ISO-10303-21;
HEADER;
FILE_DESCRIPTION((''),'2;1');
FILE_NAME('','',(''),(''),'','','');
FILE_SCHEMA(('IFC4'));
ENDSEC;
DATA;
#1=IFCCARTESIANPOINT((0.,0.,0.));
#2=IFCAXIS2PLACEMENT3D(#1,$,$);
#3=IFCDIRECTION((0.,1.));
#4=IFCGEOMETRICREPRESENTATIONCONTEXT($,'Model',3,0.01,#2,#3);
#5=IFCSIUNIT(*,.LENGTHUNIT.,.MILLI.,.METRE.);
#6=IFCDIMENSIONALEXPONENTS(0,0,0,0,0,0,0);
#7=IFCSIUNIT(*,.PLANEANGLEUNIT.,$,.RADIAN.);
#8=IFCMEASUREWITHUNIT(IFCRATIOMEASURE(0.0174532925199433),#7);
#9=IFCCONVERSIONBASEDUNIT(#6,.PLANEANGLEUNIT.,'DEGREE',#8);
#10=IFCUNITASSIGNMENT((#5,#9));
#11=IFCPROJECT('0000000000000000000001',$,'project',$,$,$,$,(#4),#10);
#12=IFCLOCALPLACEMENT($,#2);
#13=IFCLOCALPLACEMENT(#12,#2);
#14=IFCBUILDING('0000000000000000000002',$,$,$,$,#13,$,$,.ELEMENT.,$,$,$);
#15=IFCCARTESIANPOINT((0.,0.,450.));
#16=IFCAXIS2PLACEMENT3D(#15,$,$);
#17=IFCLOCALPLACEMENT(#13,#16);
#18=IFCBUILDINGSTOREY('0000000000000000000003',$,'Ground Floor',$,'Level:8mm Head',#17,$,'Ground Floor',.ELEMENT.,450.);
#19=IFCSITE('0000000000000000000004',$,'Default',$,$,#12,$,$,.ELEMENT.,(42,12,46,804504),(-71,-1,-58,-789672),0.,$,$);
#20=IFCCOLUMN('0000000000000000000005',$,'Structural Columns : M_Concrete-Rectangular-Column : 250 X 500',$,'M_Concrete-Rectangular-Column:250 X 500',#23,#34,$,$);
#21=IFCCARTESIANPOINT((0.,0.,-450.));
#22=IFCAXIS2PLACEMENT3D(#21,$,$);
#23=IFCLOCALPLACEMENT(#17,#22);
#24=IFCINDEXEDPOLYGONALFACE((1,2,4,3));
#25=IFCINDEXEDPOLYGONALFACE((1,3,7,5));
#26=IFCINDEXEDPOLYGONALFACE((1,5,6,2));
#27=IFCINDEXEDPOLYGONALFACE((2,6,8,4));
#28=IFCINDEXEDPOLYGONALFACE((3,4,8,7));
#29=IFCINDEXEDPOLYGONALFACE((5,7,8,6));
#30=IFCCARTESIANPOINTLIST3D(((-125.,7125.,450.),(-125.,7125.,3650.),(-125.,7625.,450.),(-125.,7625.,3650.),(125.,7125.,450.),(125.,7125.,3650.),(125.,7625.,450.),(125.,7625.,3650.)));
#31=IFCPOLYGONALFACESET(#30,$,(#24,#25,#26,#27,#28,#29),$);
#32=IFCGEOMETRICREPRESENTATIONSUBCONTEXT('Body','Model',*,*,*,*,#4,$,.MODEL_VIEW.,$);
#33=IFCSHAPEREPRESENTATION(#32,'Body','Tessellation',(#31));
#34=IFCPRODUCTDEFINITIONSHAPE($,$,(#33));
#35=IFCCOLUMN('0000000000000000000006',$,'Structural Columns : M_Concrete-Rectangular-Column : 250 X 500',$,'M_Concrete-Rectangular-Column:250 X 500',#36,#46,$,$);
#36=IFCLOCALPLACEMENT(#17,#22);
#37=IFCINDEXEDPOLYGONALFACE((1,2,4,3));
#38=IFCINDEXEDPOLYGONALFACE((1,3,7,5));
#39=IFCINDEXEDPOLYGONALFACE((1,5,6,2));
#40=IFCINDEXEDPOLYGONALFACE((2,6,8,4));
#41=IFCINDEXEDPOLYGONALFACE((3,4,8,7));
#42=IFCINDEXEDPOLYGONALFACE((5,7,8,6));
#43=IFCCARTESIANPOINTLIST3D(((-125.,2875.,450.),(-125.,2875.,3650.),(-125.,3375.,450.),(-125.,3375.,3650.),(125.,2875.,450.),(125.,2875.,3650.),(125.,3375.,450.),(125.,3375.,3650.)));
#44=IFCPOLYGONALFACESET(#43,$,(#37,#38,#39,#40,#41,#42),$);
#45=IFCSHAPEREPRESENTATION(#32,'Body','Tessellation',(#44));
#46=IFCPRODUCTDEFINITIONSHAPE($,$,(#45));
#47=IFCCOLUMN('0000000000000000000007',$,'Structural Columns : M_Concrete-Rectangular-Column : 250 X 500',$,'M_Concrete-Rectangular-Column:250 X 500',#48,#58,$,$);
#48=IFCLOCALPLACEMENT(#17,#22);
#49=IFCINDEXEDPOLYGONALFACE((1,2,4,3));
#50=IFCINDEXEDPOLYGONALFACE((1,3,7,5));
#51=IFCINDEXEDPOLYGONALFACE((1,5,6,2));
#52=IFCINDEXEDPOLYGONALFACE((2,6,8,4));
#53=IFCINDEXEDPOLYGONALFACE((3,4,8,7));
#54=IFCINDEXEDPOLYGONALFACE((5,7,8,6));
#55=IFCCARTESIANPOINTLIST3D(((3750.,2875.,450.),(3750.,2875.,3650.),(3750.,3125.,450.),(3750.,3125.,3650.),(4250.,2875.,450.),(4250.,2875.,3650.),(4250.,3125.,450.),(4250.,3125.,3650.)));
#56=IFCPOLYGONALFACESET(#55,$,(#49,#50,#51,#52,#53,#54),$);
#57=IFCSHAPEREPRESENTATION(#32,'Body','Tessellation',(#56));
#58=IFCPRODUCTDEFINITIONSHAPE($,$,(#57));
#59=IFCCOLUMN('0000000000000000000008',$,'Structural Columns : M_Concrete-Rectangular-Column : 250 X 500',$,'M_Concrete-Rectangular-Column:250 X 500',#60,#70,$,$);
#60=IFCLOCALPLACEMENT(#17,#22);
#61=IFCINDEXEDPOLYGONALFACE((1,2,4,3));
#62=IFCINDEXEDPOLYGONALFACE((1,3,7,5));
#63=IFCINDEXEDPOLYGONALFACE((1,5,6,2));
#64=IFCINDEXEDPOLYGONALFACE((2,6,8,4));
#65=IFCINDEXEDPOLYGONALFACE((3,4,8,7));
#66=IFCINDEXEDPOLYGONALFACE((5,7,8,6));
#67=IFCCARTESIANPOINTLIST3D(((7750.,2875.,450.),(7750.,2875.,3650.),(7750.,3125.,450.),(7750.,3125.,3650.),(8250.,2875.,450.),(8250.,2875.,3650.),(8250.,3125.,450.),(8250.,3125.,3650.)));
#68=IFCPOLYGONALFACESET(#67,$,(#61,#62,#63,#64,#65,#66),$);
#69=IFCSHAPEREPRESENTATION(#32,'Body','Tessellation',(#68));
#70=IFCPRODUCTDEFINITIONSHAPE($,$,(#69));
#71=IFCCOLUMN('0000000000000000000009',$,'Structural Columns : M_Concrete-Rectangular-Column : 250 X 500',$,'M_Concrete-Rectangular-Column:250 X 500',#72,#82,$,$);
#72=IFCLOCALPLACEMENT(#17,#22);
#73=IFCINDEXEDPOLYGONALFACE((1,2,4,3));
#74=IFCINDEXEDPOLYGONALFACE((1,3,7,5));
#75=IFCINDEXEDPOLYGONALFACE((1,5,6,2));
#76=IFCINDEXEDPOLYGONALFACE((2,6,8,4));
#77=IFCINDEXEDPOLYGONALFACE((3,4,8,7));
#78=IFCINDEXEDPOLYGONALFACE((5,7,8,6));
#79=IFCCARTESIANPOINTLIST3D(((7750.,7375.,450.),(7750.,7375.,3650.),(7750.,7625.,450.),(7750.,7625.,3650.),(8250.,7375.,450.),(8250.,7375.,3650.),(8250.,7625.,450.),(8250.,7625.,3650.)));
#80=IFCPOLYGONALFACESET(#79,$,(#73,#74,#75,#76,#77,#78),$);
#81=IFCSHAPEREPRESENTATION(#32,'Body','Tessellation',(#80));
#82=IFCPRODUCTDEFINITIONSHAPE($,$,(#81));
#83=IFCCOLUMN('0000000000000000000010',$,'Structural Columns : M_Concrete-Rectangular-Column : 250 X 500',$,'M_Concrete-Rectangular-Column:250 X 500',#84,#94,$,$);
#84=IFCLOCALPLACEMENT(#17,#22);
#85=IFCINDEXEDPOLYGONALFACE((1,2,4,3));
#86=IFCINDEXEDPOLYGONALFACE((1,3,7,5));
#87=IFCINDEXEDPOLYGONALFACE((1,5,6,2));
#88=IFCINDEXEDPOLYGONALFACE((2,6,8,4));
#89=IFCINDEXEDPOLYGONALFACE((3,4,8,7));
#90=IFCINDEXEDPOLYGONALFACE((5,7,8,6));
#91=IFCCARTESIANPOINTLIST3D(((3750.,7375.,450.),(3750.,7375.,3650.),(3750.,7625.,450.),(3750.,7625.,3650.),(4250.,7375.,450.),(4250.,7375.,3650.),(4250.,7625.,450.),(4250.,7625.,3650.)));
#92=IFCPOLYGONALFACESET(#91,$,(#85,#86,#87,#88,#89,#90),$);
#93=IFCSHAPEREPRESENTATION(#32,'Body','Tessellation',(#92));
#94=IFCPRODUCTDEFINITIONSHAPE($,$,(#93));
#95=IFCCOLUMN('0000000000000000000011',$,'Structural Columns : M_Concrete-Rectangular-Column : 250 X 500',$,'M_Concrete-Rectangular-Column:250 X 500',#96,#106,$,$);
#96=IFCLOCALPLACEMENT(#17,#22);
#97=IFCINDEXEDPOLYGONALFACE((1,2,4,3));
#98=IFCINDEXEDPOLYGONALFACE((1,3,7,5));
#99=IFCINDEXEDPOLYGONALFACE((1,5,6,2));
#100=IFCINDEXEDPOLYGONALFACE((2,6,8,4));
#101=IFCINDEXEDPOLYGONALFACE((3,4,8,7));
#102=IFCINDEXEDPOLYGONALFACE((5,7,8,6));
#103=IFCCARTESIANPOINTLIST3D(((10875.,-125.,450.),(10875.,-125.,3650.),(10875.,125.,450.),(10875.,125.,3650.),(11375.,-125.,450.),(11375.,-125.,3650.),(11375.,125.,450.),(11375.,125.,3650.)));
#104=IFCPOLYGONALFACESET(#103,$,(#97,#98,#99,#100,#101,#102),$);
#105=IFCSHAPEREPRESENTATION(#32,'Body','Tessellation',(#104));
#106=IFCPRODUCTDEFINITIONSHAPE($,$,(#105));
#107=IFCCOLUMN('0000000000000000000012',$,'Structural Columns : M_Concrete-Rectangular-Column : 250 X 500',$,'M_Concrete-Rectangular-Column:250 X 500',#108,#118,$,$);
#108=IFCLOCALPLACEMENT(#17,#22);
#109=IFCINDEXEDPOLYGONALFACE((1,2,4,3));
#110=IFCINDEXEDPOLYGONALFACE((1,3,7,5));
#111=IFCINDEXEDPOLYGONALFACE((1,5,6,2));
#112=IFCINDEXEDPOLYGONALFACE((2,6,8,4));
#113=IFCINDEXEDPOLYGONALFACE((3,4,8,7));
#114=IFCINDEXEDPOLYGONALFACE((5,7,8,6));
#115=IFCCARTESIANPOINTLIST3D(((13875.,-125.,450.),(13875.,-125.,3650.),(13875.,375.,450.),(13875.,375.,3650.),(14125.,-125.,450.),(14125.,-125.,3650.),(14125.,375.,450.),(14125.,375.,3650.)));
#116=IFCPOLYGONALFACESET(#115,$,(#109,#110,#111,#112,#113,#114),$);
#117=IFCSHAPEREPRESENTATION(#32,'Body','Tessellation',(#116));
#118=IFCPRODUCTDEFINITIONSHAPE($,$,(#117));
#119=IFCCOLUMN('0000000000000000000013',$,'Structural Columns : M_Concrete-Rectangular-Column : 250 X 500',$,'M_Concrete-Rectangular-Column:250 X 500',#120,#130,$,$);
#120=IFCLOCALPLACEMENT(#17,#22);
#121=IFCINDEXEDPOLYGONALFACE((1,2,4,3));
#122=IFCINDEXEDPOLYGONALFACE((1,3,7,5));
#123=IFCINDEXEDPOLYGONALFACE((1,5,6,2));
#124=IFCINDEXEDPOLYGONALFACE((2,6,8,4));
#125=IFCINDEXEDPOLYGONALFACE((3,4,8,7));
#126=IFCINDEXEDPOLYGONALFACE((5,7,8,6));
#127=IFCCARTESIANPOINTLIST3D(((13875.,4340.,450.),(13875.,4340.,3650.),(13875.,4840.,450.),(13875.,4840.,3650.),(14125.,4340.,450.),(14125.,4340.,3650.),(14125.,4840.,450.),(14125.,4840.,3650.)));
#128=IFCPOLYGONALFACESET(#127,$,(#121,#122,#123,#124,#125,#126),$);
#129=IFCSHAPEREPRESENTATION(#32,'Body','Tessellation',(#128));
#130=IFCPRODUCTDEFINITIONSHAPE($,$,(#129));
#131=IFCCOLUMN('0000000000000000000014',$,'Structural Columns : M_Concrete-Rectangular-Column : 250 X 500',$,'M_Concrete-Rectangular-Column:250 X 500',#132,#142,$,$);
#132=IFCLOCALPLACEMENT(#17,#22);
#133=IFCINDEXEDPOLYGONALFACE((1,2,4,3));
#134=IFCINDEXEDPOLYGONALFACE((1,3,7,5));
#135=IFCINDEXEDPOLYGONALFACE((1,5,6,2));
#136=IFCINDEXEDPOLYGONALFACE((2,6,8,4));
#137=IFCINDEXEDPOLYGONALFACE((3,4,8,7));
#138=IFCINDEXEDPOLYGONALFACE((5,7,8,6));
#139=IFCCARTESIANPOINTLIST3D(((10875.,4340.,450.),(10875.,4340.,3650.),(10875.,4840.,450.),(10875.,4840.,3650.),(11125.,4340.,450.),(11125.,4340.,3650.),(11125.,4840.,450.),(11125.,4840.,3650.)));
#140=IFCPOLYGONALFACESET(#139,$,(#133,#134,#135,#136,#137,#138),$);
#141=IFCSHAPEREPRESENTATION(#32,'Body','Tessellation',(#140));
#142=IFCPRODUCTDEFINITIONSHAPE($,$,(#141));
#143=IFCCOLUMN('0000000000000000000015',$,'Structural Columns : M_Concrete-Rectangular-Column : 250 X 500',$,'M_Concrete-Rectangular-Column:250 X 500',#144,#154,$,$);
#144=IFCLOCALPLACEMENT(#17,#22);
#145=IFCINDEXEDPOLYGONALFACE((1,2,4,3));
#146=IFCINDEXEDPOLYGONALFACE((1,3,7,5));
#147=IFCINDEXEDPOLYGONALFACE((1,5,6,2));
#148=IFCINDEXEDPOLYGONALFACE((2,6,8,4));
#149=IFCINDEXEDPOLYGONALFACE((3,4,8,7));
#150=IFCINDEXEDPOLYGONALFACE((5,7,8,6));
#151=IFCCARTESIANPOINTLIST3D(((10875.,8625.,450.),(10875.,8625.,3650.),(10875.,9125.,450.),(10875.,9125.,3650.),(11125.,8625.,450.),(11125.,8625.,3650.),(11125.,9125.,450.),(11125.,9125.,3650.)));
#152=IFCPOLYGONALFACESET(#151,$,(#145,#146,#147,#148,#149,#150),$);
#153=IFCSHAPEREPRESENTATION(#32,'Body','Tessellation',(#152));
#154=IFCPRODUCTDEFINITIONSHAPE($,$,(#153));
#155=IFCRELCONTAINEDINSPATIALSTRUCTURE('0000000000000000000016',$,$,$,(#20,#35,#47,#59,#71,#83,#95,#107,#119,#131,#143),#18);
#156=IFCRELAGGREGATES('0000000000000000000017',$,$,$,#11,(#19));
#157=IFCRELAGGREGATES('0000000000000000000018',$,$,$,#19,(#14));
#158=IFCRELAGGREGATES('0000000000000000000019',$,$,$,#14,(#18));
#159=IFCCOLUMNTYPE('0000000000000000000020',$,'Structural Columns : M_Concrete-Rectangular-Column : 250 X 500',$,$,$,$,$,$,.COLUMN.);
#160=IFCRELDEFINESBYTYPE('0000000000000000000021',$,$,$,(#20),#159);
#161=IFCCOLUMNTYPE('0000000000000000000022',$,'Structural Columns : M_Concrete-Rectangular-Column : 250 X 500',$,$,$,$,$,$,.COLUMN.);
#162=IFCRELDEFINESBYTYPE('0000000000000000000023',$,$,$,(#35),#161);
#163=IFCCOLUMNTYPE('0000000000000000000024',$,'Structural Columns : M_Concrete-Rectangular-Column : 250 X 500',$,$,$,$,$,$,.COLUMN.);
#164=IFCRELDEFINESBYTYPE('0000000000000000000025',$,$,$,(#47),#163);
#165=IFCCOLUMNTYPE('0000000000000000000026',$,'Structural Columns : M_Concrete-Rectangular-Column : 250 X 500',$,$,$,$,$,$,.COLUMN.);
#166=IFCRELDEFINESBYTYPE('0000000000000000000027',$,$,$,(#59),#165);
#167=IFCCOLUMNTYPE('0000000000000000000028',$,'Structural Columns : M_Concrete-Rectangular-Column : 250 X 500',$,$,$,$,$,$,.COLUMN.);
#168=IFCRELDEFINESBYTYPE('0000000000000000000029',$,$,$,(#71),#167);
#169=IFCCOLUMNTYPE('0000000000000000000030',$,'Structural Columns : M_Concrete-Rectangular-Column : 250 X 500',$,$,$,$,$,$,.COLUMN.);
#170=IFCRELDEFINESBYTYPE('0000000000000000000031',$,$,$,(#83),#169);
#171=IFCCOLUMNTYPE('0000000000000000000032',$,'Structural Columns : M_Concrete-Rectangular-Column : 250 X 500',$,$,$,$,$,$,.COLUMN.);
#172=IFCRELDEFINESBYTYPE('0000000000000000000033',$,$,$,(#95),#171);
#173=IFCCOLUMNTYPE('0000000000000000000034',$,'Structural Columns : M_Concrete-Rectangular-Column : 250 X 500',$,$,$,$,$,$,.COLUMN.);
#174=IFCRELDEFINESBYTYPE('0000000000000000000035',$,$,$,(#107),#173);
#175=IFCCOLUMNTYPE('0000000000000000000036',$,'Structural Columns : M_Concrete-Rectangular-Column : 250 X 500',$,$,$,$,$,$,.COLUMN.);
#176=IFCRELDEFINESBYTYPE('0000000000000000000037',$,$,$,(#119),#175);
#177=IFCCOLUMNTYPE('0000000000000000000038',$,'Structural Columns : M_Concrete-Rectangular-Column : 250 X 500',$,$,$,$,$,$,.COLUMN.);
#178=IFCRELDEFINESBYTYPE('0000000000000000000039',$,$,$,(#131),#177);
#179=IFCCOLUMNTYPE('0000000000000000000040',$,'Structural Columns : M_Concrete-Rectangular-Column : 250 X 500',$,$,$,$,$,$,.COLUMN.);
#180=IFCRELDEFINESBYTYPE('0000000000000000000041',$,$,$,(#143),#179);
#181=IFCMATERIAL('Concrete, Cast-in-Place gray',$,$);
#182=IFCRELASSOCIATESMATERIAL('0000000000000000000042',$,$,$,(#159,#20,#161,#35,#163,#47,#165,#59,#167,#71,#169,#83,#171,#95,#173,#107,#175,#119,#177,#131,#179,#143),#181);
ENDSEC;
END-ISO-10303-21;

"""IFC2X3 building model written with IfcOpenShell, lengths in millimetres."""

from ifc_helpers import new_model, entity, si_unit, converted_unit, direction, frame, frame_2d, origin, origin_2d_with_axis, place, context, subcontext, project, spatial, rectangle, extrude, source, transform, mapped, material, type_object, type_shapes, element, save


model = new_model("IFC2X3")

# Units and contexts
model_context = context("Model", 3, precision=0.01, world=origin(), true_north=direction((0.0, 1.0)))
body_context = subcontext(model_context, "Body", "Model", "MODEL_VIEW")
ifc_project = project(units=[si_unit("LENGTHUNIT", "METRE", prefix="MILLI"), converted_unit("PLANEANGLEUNIT", "DEGREE", entity("IfcRatioMeasure", 0.0174532925199433), si_unit("PLANEANGLEUNIT", "RADIAN"), dimensions=[0, 0, 0, 0, 0, 0, 0])], contexts=[model_context])

# Site, building, storey
site_placement = place(None, origin())
site = spatial("IfcSite", under=ifc_project, at=site_placement, Name="Default", CompositionType="ELEMENT", RefLatitude=(42, 12, 46, 804504), RefLongitude=(-71, -1, -58, -789672), RefElevation=0.0)
building_placement = place(site_placement, origin())
building = spatial("IfcBuilding", under=site, at=building_placement, CompositionType="ELEMENT")
storey_placement = place(building_placement, frame((0.0, 0.0, 450.0)))
storey = spatial("IfcBuildingStorey", under=building, at=storey_placement, Name="Ground Floor", ObjectType="Level:8mm Head", LongName="Ground Floor", CompositionType="ELEMENT", Elevation=450.0)

# Columns
ifc_material = material(Name="Concrete, Cast-in-Place gray")
column_type_1 = type_object("IfcColumnType", Name="Structural Columns : M_Concrete-Rectangular-Column : 250 X 500", PredefinedType="COLUMN", material=ifc_material)
shared_shape_1 = source(origin(), body_context, "Body", "SweptSolid", [
    extrude(rectangle(XDim=500.0, YDim=250.0, at=frame_2d((0.0, 0.0), x_axis=(1.0, 0.0))), frame((0.0, 7375.0, 450.0), z_axis=(0.0, 0.0, 1.0), x_axis=(0.0, -1.0, 0.0)), (0.0, 0.0, 1.0), 3200.0),
])
type_shapes(column_type_1, [shared_shape_1])
column_1_placement = place(storey_placement, frame((0.0, 0.0, -450.0)))
element("IfcColumn", 1, at=column_1_placement, inside=storey, type_object=column_type_1, material=ifc_material, Name="Structural Columns : M_Concrete-Rectangular-Column : 250 X 500", ObjectType="M_Concrete-Rectangular-Column:250 X 500", context=body_context, shape_type="MappedRepresentation", body=[
    mapped(shared_shape_1, transform((0.0, 0.0, 0.0), scale=1.0)),
])
column_type_2 = type_object("IfcColumnType", Name="Structural Columns : M_Concrete-Rectangular-Column : 250 X 500", PredefinedType="COLUMN", material=ifc_material)
shared_shape_2 = source(origin(), body_context, "Body", "SweptSolid", [
    extrude(rectangle(XDim=500.0, YDim=250.0, at=origin_2d_with_axis()), frame((0.0, 3125.0, 450.0), z_axis=(0.0, 0.0, 1.0), x_axis=(0.0, -1.0, 0.0)), (0.0, 0.0, 1.0), 3200.0),
])
type_shapes(column_type_2, [shared_shape_2])
column_2_placement = place(storey_placement, frame((0.0, 0.0, -450.0)))
element("IfcColumn", 2, at=column_2_placement, inside=storey, type_object=column_type_2, material=ifc_material, Name="Structural Columns : M_Concrete-Rectangular-Column : 250 X 500", ObjectType="M_Concrete-Rectangular-Column:250 X 500", context=body_context, shape_type="MappedRepresentation", body=[
    mapped(shared_shape_2, transform((0.0, 0.0, 0.0), scale=1.0)),
])
column_type_3 = type_object("IfcColumnType", Name="Structural Columns : M_Concrete-Rectangular-Column : 250 X 500", PredefinedType="COLUMN", material=ifc_material)
shared_shape_3 = source(origin(), body_context, "Body", "SweptSolid", [
    extrude(rectangle(XDim=250.0, YDim=500.0, at=frame_2d((0.0, 0.0), x_axis=(1.0, 0.0))), frame((4000.0, 3000.0, 450.0), z_axis=(0.0, 0.0, 1.0), x_axis=(0.0, -1.0, 0.0)), (0.0, 0.0, 1.0), 3200.0),
])
type_shapes(column_type_3, [shared_shape_3])
column_3_placement = place(storey_placement, frame((0.0, 0.0, -450.0)))
element("IfcColumn", 3, at=column_3_placement, inside=storey, type_object=column_type_3, material=ifc_material, Name="Structural Columns : M_Concrete-Rectangular-Column : 250 X 500", ObjectType="M_Concrete-Rectangular-Column:250 X 500", context=body_context, shape_type="MappedRepresentation", body=[
    mapped(shared_shape_3, transform((0.0, 0.0, 0.0), scale=1.0)),
])
column_type_4 = type_object("IfcColumnType", Name="Structural Columns : M_Concrete-Rectangular-Column : 250 X 500", PredefinedType="COLUMN", material=ifc_material)
shared_shape_4 = source(origin(), body_context, "Body", "SweptSolid", [
    extrude(rectangle(XDim=250.0, YDim=500.0, at=frame_2d((0.0, 0.0), x_axis=(1.0, 0.0))), frame((8000.0, 3000.0, 450.0), z_axis=(0.0, 0.0, 1.0), x_axis=(0.0, -1.0, 0.0)), (0.0, 0.0, 1.0), 3200.0),
])
type_shapes(column_type_4, [shared_shape_4])
column_4_placement = place(storey_placement, frame((0.0, 0.0, -450.0)))
element("IfcColumn", 4, at=column_4_placement, inside=storey, type_object=column_type_4, material=ifc_material, Name="Structural Columns : M_Concrete-Rectangular-Column : 250 X 500", ObjectType="M_Concrete-Rectangular-Column:250 X 500", context=body_context, shape_type="MappedRepresentation", body=[
    mapped(shared_shape_4, transform((0.0, 0.0, 0.0), scale=1.0)),
])
column_type_5 = type_object("IfcColumnType", Name="Structural Columns : M_Concrete-Rectangular-Column : 250 X 500", PredefinedType="COLUMN", material=ifc_material)
shared_shape_5 = source(origin(), body_context, "Body", "SweptSolid", [
    extrude(rectangle(XDim=250.0, YDim=500.0, at=frame_2d((0.0, 0.0), x_axis=(1.0, 0.0))), frame((8000.0, 7500.0, 450.0), z_axis=(0.0, 0.0, 1.0), x_axis=(0.0, -1.0, 0.0)), (0.0, 0.0, 1.0), 3200.0),
])
type_shapes(column_type_5, [shared_shape_5])
column_5_placement = place(storey_placement, frame((0.0, 0.0, -450.0)))
element("IfcColumn", 5, at=column_5_placement, inside=storey, type_object=column_type_5, material=ifc_material, Name="Structural Columns : M_Concrete-Rectangular-Column : 250 X 500", ObjectType="M_Concrete-Rectangular-Column:250 X 500", context=body_context, shape_type="MappedRepresentation", body=[
    mapped(shared_shape_5, transform((0.0, 0.0, 0.0), scale=1.0)),
])
column_type_6 = type_object("IfcColumnType", Name="Structural Columns : M_Concrete-Rectangular-Column : 250 X 500", PredefinedType="COLUMN", material=ifc_material)
shared_shape_6 = source(origin(), body_context, "Body", "SweptSolid", [
    extrude(rectangle(XDim=250.0, YDim=500.0, at=origin_2d_with_axis()), frame((4000.0, 7500.0, 450.0), z_axis=(0.0, 0.0, 1.0), x_axis=(0.0, -1.0, 0.0)), (0.0, 0.0, 1.0), 3200.0),
])
type_shapes(column_type_6, [shared_shape_6])
column_6_placement = place(storey_placement, frame((0.0, 0.0, -450.0)))
element("IfcColumn", 6, at=column_6_placement, inside=storey, type_object=column_type_6, material=ifc_material, Name="Structural Columns : M_Concrete-Rectangular-Column : 250 X 500", ObjectType="M_Concrete-Rectangular-Column:250 X 500", context=body_context, shape_type="MappedRepresentation", body=[
    mapped(shared_shape_6, transform((0.0, 0.0, 0.0), scale=1.0)),
])
column_type_7 = type_object("IfcColumnType", Name="Structural Columns : M_Concrete-Rectangular-Column : 250 X 500", PredefinedType="COLUMN", material=ifc_material)
shared_shape_7 = source(origin(), body_context, "Body", "SweptSolid", [
    extrude(rectangle(XDim=250.0, YDim=500.0, at=origin_2d_with_axis()), frame((11125.0, 0.0, 450.0), z_axis=(0.0, 0.0, 1.0), x_axis=(0.0, -1.0, 0.0)), (0.0, 0.0, 1.0), 3200.0),
])
type_shapes(column_type_7, [shared_shape_7])
column_7_placement = place(storey_placement, frame((0.0, 0.0, -450.0)))
element("IfcColumn", 7, at=column_7_placement, inside=storey, type_object=column_type_7, material=ifc_material, Name="Structural Columns : M_Concrete-Rectangular-Column : 250 X 500", ObjectType="M_Concrete-Rectangular-Column:250 X 500", context=body_context, shape_type="MappedRepresentation", body=[
    mapped(shared_shape_7, transform((0.0, 0.0, 0.0), scale=1.0)),
])
column_type_8 = type_object("IfcColumnType", Name="Structural Columns : M_Concrete-Rectangular-Column : 250 X 500", PredefinedType="COLUMN", material=ifc_material)
shared_shape_8 = source(origin(), body_context, "Body", "SweptSolid", [
    extrude(rectangle(XDim=500.0, YDim=250.0, at=frame_2d((0.0, 0.0), x_axis=(1.0, 0.0))), frame((14000.0, 125.0, 450.0), z_axis=(0.0, 0.0, 1.0), x_axis=(0.0, -1.0, 0.0)), (0.0, 0.0, 1.0), 3200.0),
])
type_shapes(column_type_8, [shared_shape_8])
column_8_placement = place(storey_placement, frame((0.0, 0.0, -450.0)))
element("IfcColumn", 8, at=column_8_placement, inside=storey, type_object=column_type_8, material=ifc_material, Name="Structural Columns : M_Concrete-Rectangular-Column : 250 X 500", ObjectType="M_Concrete-Rectangular-Column:250 X 500", context=body_context, shape_type="MappedRepresentation", body=[
    mapped(shared_shape_8, transform((0.0, 0.0, 0.0), scale=1.0)),
])
column_type_9 = type_object("IfcColumnType", Name="Structural Columns : M_Concrete-Rectangular-Column : 250 X 500", PredefinedType="COLUMN", material=ifc_material)
shared_shape_9 = source(origin(), body_context, "Body", "SweptSolid", [
    extrude(rectangle(XDim=500.0, YDim=250.0, at=origin_2d_with_axis()), frame((14000.0, 4590.0, 450.0), z_axis=(0.0, 0.0, 1.0), x_axis=(0.0, -1.0, 0.0)), (0.0, 0.0, 1.0), 3200.0),
])
type_shapes(column_type_9, [shared_shape_9])
column_9_placement = place(storey_placement, frame((0.0, 0.0, -450.0)))
element("IfcColumn", 9, at=column_9_placement, inside=storey, type_object=column_type_9, material=ifc_material, Name="Structural Columns : M_Concrete-Rectangular-Column : 250 X 500", ObjectType="M_Concrete-Rectangular-Column:250 X 500", context=body_context, shape_type="MappedRepresentation", body=[
    mapped(shared_shape_9, transform((0.0, 0.0, 0.0), scale=1.0)),
])
column_type_10 = type_object("IfcColumnType", Name="Structural Columns : M_Concrete-Rectangular-Column : 250 X 500", PredefinedType="COLUMN", material=ifc_material)
shared_shape_10 = source(origin(), body_context, "Body", "SweptSolid", [
    extrude(rectangle(XDim=500.0, YDim=250.0, at=origin_2d_with_axis()), frame((11000.0, 4590.0, 450.0), z_axis=(0.0, 0.0, 1.0), x_axis=(0.0, -1.0, 0.0)), (0.0, 0.0, 1.0), 3200.0),
])
type_shapes(column_type_10, [shared_shape_10])
column_10_placement = place(storey_placement, frame((0.0, 0.0, -450.0)))
element("IfcColumn", 10, at=column_10_placement, inside=storey, type_object=column_type_10, material=ifc_material, Name="Structural Columns : M_Concrete-Rectangular-Column : 250 X 500", ObjectType="M_Concrete-Rectangular-Column:250 X 500", context=body_context, shape_type="MappedRepresentation", body=[
    mapped(shared_shape_10, transform((0.0, 0.0, 0.0), scale=1.0)),
])
column_type_11 = type_object("IfcColumnType", Name="Structural Columns : M_Concrete-Rectangular-Column : 250 X 500", PredefinedType="COLUMN", material=ifc_material)
shared_shape_11 = source(origin(), body_context, "Body", "SweptSolid", [
    extrude(rectangle(XDim=500.0, YDim=250.0, at=frame_2d((0.0, 0.0), x_axis=(1.0, 0.0))), frame((11000.0, 8875.0, 450.0), z_axis=(0.0, 0.0, 1.0), x_axis=(0.0, -1.0, 0.0)), (0.0, 0.0, 1.0), 3200.0),
])
type_shapes(column_type_11, [shared_shape_11])
column_11_placement = place(storey_placement, frame((0.0, 0.0, -450.0)))
element("IfcColumn", 11, at=column_11_placement, inside=storey, type_object=column_type_11, material=ifc_material, Name="Structural Columns : M_Concrete-Rectangular-Column : 250 X 500", ObjectType="M_Concrete-Rectangular-Column:250 X 500", context=body_context, shape_type="MappedRepresentation", body=[
    mapped(shared_shape_11, transform((0.0, 0.0, 0.0), scale=1.0)),
])

save(model, "model.ifc")
